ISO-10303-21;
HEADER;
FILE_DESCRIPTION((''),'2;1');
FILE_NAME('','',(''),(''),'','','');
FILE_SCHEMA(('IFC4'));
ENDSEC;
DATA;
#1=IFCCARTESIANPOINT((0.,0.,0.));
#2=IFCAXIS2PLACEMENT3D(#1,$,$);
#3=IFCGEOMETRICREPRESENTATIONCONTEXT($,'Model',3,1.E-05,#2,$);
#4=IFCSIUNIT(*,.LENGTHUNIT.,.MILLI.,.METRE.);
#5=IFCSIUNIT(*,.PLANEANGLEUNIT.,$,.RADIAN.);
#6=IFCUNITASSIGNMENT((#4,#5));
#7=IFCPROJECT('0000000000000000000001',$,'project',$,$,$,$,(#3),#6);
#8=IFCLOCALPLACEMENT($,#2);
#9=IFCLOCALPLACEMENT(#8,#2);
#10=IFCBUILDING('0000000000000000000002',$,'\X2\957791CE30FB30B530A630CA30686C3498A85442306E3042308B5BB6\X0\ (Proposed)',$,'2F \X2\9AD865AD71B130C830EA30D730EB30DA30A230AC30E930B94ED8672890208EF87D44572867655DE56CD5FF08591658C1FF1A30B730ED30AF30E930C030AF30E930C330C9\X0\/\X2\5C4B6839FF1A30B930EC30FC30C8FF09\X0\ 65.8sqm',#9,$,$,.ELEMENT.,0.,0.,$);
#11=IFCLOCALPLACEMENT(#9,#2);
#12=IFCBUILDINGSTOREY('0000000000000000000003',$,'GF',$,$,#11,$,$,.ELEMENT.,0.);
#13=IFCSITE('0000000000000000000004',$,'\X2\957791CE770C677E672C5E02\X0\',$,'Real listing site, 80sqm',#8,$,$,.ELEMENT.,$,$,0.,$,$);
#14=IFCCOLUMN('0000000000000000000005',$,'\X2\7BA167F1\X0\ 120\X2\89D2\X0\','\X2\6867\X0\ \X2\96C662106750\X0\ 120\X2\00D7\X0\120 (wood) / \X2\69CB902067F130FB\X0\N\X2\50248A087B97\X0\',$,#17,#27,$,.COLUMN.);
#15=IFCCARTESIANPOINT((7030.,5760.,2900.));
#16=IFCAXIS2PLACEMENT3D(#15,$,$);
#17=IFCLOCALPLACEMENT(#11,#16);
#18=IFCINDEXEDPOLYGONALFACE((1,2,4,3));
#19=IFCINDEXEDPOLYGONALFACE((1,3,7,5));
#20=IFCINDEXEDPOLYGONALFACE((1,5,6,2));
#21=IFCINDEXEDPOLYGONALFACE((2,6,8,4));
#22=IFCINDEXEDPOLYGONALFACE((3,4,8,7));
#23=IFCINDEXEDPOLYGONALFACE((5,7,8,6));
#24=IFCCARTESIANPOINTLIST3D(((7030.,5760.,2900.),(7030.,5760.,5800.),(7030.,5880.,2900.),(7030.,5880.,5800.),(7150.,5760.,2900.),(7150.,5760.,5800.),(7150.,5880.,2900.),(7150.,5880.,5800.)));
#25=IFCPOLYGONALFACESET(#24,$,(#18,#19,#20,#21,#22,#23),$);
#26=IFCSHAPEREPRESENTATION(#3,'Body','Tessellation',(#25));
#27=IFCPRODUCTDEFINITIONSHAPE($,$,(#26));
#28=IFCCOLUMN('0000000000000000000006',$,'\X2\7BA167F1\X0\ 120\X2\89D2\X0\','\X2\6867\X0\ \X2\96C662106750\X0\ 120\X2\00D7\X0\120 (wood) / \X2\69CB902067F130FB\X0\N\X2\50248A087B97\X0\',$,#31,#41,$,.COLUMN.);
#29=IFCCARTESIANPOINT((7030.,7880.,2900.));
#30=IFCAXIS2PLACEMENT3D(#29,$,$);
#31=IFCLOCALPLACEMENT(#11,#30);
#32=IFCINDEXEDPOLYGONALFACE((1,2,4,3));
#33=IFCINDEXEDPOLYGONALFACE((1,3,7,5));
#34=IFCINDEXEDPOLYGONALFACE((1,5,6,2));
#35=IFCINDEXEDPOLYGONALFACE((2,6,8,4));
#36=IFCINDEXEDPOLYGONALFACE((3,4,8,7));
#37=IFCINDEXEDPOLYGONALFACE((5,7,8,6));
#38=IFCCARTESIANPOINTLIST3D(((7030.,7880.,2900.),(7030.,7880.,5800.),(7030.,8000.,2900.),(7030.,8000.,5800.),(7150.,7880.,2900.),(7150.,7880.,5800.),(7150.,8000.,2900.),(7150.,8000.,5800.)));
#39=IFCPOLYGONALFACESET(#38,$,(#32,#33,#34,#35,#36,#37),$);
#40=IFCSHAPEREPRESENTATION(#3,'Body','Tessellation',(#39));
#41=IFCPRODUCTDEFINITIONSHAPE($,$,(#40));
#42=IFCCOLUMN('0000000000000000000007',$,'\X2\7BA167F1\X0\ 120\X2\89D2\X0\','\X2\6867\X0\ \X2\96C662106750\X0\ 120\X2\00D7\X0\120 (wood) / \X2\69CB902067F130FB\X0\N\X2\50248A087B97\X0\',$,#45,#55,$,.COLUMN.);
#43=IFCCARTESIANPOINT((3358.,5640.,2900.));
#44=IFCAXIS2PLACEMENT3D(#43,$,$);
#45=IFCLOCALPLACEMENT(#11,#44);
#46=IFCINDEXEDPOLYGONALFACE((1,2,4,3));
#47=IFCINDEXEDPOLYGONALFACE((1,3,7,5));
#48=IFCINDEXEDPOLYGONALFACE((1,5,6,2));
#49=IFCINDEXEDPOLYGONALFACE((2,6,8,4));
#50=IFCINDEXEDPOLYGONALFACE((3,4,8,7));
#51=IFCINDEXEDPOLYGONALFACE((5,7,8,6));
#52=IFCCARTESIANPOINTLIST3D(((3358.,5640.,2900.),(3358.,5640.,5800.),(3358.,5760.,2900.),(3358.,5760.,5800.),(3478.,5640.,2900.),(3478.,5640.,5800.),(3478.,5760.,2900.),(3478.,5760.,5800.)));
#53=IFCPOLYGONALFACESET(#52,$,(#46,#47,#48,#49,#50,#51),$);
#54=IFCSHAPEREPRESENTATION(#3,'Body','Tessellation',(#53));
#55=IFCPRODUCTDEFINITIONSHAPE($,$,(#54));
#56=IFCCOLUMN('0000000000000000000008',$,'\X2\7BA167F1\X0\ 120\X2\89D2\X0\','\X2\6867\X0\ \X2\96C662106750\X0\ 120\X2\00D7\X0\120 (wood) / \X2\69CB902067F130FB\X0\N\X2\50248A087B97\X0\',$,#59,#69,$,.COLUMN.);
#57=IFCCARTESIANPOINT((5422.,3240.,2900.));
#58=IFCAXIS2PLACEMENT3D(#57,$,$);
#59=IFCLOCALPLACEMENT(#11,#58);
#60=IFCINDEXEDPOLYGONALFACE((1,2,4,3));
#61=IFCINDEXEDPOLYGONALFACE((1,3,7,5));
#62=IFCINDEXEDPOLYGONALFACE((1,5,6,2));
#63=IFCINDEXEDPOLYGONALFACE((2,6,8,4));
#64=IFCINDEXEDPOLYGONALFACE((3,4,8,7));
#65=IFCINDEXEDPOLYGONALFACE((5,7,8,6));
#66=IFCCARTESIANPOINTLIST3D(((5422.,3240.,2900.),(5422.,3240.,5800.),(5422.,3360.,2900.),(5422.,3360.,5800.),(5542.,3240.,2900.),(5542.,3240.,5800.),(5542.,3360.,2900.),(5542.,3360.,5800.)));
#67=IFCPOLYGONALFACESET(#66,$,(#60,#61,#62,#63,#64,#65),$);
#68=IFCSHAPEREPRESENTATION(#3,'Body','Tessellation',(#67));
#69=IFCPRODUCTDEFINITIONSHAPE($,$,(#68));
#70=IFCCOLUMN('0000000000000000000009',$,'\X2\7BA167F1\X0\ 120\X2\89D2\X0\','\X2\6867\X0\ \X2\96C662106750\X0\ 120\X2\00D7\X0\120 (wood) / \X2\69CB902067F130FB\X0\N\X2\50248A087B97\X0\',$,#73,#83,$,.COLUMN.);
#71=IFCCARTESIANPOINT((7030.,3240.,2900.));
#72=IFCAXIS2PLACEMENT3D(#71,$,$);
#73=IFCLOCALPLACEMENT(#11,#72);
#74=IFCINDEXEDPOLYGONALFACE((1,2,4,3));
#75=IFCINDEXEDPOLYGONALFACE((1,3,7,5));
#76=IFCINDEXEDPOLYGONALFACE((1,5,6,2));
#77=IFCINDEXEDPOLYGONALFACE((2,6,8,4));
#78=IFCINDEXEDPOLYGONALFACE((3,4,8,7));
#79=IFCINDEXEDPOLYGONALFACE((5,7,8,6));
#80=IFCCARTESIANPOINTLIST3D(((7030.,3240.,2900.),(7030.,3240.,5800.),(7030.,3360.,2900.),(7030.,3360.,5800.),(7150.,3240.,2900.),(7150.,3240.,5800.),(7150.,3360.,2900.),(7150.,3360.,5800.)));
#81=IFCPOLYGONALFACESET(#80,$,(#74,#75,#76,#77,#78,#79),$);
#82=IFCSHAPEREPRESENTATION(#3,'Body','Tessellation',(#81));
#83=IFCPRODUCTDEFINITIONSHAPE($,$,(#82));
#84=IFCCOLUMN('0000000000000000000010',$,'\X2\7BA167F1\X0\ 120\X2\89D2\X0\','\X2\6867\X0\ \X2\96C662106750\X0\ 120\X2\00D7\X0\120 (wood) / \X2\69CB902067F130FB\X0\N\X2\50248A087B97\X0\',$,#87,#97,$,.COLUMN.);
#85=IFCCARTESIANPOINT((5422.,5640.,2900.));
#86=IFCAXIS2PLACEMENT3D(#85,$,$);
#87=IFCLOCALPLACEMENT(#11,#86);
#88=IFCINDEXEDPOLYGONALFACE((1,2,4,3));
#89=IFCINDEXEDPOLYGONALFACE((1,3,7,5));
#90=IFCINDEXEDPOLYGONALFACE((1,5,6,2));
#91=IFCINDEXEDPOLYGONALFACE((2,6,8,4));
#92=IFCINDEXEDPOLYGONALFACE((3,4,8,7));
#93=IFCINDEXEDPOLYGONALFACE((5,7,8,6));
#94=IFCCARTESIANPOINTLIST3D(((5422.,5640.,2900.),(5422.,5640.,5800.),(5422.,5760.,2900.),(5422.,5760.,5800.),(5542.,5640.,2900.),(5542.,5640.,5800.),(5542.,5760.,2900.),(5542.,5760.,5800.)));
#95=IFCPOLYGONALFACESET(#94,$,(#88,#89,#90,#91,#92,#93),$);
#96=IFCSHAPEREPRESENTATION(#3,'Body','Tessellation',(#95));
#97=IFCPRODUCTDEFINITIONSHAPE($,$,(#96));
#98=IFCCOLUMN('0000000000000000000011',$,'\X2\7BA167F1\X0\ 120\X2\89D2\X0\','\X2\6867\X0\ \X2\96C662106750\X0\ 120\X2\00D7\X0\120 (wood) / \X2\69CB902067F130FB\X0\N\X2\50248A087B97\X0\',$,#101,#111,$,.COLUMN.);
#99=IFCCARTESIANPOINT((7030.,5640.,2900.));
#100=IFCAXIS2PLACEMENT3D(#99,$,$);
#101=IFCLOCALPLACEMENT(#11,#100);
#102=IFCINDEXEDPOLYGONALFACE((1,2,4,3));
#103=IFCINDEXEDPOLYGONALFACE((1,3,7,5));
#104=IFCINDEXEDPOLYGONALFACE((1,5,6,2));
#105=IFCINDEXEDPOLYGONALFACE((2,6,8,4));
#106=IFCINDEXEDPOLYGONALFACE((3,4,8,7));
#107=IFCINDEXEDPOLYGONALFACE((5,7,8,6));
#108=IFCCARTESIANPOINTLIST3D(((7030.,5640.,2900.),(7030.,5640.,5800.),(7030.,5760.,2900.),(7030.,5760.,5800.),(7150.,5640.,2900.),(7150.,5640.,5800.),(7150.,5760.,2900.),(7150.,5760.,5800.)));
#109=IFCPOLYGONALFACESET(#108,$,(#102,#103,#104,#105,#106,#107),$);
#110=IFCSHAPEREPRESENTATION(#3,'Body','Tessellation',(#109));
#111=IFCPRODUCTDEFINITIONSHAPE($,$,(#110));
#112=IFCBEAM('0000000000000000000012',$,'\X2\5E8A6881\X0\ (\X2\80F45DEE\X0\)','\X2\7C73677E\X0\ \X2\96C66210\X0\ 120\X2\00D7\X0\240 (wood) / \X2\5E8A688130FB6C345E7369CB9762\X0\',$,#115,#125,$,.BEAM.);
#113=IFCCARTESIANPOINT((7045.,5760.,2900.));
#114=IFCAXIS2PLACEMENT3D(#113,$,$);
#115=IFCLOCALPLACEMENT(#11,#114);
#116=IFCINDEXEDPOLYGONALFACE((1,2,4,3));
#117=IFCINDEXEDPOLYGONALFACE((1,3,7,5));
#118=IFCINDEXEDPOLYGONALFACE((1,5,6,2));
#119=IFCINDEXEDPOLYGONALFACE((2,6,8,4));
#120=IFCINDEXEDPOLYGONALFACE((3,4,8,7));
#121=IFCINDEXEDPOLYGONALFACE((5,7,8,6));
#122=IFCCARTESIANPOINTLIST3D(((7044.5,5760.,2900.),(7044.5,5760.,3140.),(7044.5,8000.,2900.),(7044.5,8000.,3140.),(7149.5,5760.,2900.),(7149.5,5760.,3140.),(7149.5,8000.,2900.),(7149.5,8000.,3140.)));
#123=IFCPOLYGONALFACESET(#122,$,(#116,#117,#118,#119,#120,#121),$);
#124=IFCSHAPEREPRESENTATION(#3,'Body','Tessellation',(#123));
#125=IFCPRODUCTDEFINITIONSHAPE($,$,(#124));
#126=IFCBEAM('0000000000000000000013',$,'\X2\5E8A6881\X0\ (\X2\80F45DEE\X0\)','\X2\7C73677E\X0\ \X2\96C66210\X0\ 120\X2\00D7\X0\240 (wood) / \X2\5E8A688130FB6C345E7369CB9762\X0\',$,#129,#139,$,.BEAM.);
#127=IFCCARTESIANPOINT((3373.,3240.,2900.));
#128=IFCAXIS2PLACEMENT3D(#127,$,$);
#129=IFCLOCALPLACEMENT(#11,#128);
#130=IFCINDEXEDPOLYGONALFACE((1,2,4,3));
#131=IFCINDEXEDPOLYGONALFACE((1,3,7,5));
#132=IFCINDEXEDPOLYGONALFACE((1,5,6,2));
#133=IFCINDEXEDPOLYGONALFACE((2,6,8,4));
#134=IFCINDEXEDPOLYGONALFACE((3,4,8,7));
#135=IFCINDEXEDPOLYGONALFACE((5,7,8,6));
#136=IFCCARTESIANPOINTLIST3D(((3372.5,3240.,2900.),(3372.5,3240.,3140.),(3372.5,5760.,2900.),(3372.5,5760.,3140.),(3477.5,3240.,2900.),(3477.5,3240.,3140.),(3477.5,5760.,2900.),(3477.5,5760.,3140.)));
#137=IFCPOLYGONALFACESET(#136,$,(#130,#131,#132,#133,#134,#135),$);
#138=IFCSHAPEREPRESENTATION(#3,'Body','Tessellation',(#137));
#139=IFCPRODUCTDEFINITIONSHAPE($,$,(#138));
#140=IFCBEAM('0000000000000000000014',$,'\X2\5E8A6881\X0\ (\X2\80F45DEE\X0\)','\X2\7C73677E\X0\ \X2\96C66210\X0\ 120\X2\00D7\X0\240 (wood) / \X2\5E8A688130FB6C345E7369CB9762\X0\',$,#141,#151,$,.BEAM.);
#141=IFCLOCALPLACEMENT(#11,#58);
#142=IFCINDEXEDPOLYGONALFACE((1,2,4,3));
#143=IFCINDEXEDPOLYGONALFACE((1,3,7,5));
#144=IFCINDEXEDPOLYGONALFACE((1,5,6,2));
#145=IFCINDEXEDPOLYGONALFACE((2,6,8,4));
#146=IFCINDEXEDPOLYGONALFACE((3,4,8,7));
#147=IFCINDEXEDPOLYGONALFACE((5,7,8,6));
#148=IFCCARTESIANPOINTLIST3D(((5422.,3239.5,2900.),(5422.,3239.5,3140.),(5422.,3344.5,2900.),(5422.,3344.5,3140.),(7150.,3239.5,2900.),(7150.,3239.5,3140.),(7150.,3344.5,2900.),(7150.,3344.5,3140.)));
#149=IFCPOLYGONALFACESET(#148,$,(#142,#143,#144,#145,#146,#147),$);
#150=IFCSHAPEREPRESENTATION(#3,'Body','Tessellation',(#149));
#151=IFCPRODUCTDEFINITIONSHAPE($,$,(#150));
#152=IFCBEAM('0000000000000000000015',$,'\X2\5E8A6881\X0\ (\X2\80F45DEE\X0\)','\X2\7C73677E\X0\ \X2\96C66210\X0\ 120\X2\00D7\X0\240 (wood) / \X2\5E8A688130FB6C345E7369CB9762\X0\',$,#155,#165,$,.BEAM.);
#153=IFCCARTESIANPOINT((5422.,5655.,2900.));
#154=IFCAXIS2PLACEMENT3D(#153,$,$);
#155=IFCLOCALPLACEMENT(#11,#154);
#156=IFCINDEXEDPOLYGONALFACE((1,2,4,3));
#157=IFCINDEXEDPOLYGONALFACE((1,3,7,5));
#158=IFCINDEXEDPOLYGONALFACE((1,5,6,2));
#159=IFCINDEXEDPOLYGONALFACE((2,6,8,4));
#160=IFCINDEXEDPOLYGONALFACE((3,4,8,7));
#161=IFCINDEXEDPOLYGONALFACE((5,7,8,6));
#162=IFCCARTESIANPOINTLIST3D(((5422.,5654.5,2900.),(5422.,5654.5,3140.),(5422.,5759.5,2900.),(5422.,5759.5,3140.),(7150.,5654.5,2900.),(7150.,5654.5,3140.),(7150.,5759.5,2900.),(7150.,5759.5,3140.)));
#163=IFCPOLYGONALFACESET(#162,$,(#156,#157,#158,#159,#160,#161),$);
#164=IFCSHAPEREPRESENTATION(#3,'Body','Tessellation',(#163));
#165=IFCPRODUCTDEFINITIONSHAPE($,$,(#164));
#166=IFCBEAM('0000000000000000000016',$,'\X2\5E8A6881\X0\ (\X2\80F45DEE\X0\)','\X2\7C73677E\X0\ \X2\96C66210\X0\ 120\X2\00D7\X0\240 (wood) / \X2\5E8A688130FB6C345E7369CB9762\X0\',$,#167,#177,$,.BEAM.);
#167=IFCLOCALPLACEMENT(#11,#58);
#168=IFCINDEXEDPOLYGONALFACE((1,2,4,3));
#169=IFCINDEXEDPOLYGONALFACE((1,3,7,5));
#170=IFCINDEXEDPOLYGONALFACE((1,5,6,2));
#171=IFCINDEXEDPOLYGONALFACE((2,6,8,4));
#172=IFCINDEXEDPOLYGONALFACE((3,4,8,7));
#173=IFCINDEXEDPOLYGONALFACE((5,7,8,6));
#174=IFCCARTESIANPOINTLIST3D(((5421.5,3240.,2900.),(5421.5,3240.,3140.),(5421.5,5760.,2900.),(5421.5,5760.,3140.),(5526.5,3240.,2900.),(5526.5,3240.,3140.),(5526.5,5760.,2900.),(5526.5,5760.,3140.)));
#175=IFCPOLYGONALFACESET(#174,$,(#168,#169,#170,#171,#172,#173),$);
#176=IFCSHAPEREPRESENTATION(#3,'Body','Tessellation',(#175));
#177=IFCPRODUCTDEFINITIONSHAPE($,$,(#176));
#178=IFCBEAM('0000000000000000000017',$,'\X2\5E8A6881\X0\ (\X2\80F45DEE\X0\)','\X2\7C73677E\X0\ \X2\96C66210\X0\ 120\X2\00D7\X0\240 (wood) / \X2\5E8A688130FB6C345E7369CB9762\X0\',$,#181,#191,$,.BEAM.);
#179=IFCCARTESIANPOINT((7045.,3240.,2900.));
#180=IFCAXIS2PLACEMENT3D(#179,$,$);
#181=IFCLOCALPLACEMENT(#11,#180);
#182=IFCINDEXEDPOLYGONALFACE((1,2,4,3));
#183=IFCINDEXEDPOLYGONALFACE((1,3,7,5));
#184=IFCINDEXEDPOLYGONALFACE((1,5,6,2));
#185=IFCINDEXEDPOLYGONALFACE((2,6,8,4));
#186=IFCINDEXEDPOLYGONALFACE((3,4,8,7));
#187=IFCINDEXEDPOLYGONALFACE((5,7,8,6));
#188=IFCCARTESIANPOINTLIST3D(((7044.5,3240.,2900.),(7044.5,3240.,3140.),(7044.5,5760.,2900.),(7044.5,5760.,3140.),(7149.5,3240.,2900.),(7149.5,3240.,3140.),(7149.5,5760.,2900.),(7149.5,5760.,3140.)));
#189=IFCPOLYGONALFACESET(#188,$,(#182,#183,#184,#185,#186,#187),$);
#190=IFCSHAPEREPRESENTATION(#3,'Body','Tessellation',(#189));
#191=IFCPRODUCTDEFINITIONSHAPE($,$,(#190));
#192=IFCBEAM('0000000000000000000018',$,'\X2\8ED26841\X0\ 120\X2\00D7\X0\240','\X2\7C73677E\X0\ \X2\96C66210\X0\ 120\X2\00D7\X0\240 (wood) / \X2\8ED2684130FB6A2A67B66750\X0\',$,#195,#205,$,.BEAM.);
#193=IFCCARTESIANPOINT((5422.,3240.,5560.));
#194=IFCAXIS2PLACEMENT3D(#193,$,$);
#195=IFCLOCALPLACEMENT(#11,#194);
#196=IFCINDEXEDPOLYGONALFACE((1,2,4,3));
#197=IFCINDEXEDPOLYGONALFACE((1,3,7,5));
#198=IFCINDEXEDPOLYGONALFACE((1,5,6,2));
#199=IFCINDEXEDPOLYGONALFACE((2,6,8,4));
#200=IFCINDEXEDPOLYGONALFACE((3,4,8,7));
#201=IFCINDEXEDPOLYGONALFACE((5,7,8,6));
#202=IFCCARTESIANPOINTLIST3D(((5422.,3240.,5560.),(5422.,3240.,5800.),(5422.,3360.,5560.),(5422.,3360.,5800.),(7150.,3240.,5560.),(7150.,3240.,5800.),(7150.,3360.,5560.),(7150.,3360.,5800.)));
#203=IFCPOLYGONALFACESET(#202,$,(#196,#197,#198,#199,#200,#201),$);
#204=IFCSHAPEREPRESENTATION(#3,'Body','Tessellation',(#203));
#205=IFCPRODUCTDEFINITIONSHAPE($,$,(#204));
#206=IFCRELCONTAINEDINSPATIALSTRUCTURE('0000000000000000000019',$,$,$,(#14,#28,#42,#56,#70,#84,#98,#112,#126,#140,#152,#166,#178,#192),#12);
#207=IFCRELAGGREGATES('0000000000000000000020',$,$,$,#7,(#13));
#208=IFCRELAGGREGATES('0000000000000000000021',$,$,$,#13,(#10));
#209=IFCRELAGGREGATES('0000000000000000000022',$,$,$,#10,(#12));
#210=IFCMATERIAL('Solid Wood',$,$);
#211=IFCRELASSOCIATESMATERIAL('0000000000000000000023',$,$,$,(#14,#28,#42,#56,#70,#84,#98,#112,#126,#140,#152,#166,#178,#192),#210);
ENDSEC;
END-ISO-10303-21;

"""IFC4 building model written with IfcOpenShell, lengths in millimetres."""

from ifc_helpers import new_model, si_unit, frame, frame_2d, origin, place, context, project, spatial, rectangle, extrude, material, element, save


model = new_model("IFC4")

# Units and contexts
model_context = context("Model", 3, precision=1e-05, world=origin())
ifc_project = project(units=[si_unit("LENGTHUNIT", "METRE", prefix="MILLI"), si_unit("PLANEANGLEUNIT", "RADIAN")], contexts=[model_context])

# Site, building, storey
site_placement = place(None, origin())
site = spatial("IfcSite", under=ifc_project, at=site_placement, Name="長野県松本市", ObjectType="Real listing site, 80sqm", CompositionType="ELEMENT", RefElevation=0.0)
building_placement = place(site_placement, origin())
building = spatial("IfcBuilding", under=site, at=building_placement, Name="長野・サウナと水風呂のある家 (Proposed)", ObjectType="2F 高断熱トリプルペアガラス付木造軸組在来工法（外壁：シロクラダクラッド/屋根：スレート） 65.8sqm", CompositionType="ELEMENT", ElevationOfRefHeight=0.0, ElevationOfTerrain=0.0)
storey_placement = place(building_placement, origin())
storey = spatial("IfcBuildingStorey", under=building, at=storey_placement, Name="GF", CompositionType="ELEMENT", Elevation=0.0)

# Columns
ifc_material_1 = material(Name="Solid Wood")
column_1_placement = place(storey_placement, frame((7030.0, 5760.0, 2900.0)))
element("IfcColumn", 1, at=column_1_placement, inside=storey, material=ifc_material_1, Name="管柱 120角", Description="桧 集成材 120×120 (wood) / 構造柱・N値計算", PredefinedType="COLUMN", context=model_context, shape_type="SweptSolid", body=[
    extrude(rectangle(XDim=120.0, YDim=120.0, at=frame_2d((60.0, 60.0))), frame((7030.0, 5760.0, 2900.0)), (0.0, 0.0, 1.0), 2900.0),
])
column_2_placement = place(storey_placement, frame((7030.0, 7880.0, 2900.0)))
element("IfcColumn", 2, at=column_2_placement, inside=storey, material=ifc_material_1, Name="管柱 120角", Description="桧 集成材 120×120 (wood) / 構造柱・N値計算", PredefinedType="COLUMN", context=model_context, shape_type="SweptSolid", body=[
    extrude(rectangle(XDim=120.0, YDim=120.0, at=frame_2d((60.0, 60.0))), frame((7030.0, 7880.0, 2900.0)), (0.0, 0.0, 1.0), 2900.0),
])
column_3_placement = place(storey_placement, frame((3358.0, 5640.0, 2900.0)))
element("IfcColumn", 3, at=column_3_placement, inside=storey, material=ifc_material_1, Name="管柱 120角", Description="桧 集成材 120×120 (wood) / 構造柱・N値計算", PredefinedType="COLUMN", context=model_context, shape_type="SweptSolid", body=[
    extrude(rectangle(XDim=120.0, YDim=120.0, at=frame_2d((60.0, 60.0))), frame((3358.0, 5640.0, 2900.0)), (0.0, 0.0, 1.0), 2900.0),
])
column_4_placement = place(storey_placement, frame((5422.0, 3240.0, 2900.0)))
element("IfcColumn", 4, at=column_4_placement, inside=storey, material=ifc_material_1, Name="管柱 120角", Description="桧 集成材 120×120 (wood) / 構造柱・N値計算", PredefinedType="COLUMN", context=model_context, shape_type="SweptSolid", body=[
    extrude(rectangle(XDim=120.0, YDim=120.0, at=frame_2d((60.0, 60.0))), frame((5422.0, 3240.0, 2900.0)), (0.0, 0.0, 1.0), 2900.0),
])
column_5_placement = place(storey_placement, frame((7030.0, 3240.0, 2900.0)))
element("IfcColumn", 5, at=column_5_placement, inside=storey, material=ifc_material_1, Name="管柱 120角", Description="桧 集成材 120×120 (wood) / 構造柱・N値計算", PredefinedType="COLUMN", context=model_context, shape_type="SweptSolid", body=[
    extrude(rectangle(XDim=120.0, YDim=120.0, at=frame_2d((60.0, 60.0))), frame((7030.0, 3240.0, 2900.0)), (0.0, 0.0, 1.0), 2900.0),
])
column_6_placement = place(storey_placement, frame((5422.0, 5640.0, 2900.0)))
element("IfcColumn", 6, at=column_6_placement, inside=storey, material=ifc_material_1, Name="管柱 120角", Description="桧 集成材 120×120 (wood) / 構造柱・N値計算", PredefinedType="COLUMN", context=model_context, shape_type="SweptSolid", body=[
    extrude(rectangle(XDim=120.0, YDim=120.0, at=frame_2d((60.0, 60.0))), frame((5422.0, 5640.0, 2900.0)), (0.0, 0.0, 1.0), 2900.0),
])
column_7_placement = place(storey_placement, frame((7030.0, 5640.0, 2900.0)))
element("IfcColumn", 7, at=column_7_placement, inside=storey, material=ifc_material_1, Name="管柱 120角", Description="桧 集成材 120×120 (wood) / 構造柱・N値計算", PredefinedType="COLUMN", context=model_context, shape_type="SweptSolid", body=[
    extrude(rectangle(XDim=120.0, YDim=120.0, at=frame_2d((60.0, 60.0))), frame((7030.0, 5640.0, 2900.0)), (0.0, 0.0, 1.0), 2900.0),
])

# Beams
beam_1_placement = place(storey_placement, frame((7045.0, 5760.0, 2900.0)))
element("IfcBeam", 8, at=beam_1_placement, inside=storey, material=ifc_material_1, Name="床梁 (胴差)", Description="米松 集成 120×240 (wood) / 床梁・水平構面", PredefinedType="BEAM", context=model_context, shape_type="SweptSolid", body=[
    extrude(rectangle(XDim=105.0, YDim=2240.0, at=frame_2d((52.0, 1120.0))), frame((7045.0, 5760.0, 2900.0)), (0.0, 0.0, 1.0), 240.0),
])
beam_2_placement = place(storey_placement, frame((3373.0, 3240.0, 2900.0)))
element("IfcBeam", 9, at=beam_2_placement, inside=storey, material=ifc_material_1, Name="床梁 (胴差)", Description="米松 集成 120×240 (wood) / 床梁・水平構面", PredefinedType="BEAM", context=model_context, shape_type="SweptSolid", body=[
    extrude(rectangle(XDim=105.0, YDim=2520.0, at=frame_2d((52.0, 1260.0))), frame((3373.0, 3240.0, 2900.0)), (0.0, 0.0, 1.0), 240.0),
])
beam_3_placement = place(storey_placement, frame((5422.0, 3240.0, 2900.0)))
element("IfcBeam", 10, at=beam_3_placement, inside=storey, material=ifc_material_1, Name="床梁 (胴差)", Description="米松 集成 120×240 (wood) / 床梁・水平構面", PredefinedType="BEAM", context=model_context, shape_type="SweptSolid", body=[
    extrude(rectangle(XDim=1728.0, YDim=105.0, at=frame_2d((864.0, 52.0))), frame((5422.0, 3240.0, 2900.0)), (0.0, 0.0, 1.0), 240.0),
])
beam_4_placement = place(storey_placement, frame((5422.0, 5655.0, 2900.0)))
element("IfcBeam", 11, at=beam_4_placement, inside=storey, material=ifc_material_1, Name="床梁 (胴差)", Description="米松 集成 120×240 (wood) / 床梁・水平構面", PredefinedType="BEAM", context=model_context, shape_type="SweptSolid", body=[
    extrude(rectangle(XDim=1728.0, YDim=105.0, at=frame_2d((864.0, 52.0))), frame((5422.0, 5655.0, 2900.0)), (0.0, 0.0, 1.0), 240.0),
])
beam_5_placement = place(storey_placement, frame((5422.0, 3240.0, 2900.0)))
element("IfcBeam", 12, at=beam_5_placement, inside=storey, material=ifc_material_1, Name="床梁 (胴差)", Description="米松 集成 120×240 (wood) / 床梁・水平構面", PredefinedType="BEAM", context=model_context, shape_type="SweptSolid", body=[
    extrude(rectangle(XDim=105.0, YDim=2520.0, at=frame_2d((52.0, 1260.0))), frame((5422.0, 3240.0, 2900.0)), (0.0, 0.0, 1.0), 240.0),
])
beam_6_placement = place(storey_placement, frame((7045.0, 3240.0, 2900.0)))
element("IfcBeam", 13, at=beam_6_placement, inside=storey, material=ifc_material_1, Name="床梁 (胴差)", Description="米松 集成 120×240 (wood) / 床梁・水平構面", PredefinedType="BEAM", context=model_context, shape_type="SweptSolid", body=[
    extrude(rectangle(XDim=105.0, YDim=2520.0, at=frame_2d((52.0, 1260.0))), frame((7045.0, 3240.0, 2900.0)), (0.0, 0.0, 1.0), 240.0),
])
beam_7_placement = place(storey_placement, frame((5422.0, 3240.0, 5560.0)))
element("IfcBeam", 14, at=beam_7_placement, inside=storey, material=ifc_material_1, Name="軒桁 120×240", Description="米松 集成 120×240 (wood) / 軒桁・横架材", PredefinedType="BEAM", context=model_context, shape_type="SweptSolid", body=[
    extrude(rectangle(XDim=1728.0, YDim=120.0, at=frame_2d((864.0, 60.0))), frame((5422.0, 3240.0, 5560.0)), (0.0, 0.0, 1.0), 240.0),
])

save(model, "model.ifc")
